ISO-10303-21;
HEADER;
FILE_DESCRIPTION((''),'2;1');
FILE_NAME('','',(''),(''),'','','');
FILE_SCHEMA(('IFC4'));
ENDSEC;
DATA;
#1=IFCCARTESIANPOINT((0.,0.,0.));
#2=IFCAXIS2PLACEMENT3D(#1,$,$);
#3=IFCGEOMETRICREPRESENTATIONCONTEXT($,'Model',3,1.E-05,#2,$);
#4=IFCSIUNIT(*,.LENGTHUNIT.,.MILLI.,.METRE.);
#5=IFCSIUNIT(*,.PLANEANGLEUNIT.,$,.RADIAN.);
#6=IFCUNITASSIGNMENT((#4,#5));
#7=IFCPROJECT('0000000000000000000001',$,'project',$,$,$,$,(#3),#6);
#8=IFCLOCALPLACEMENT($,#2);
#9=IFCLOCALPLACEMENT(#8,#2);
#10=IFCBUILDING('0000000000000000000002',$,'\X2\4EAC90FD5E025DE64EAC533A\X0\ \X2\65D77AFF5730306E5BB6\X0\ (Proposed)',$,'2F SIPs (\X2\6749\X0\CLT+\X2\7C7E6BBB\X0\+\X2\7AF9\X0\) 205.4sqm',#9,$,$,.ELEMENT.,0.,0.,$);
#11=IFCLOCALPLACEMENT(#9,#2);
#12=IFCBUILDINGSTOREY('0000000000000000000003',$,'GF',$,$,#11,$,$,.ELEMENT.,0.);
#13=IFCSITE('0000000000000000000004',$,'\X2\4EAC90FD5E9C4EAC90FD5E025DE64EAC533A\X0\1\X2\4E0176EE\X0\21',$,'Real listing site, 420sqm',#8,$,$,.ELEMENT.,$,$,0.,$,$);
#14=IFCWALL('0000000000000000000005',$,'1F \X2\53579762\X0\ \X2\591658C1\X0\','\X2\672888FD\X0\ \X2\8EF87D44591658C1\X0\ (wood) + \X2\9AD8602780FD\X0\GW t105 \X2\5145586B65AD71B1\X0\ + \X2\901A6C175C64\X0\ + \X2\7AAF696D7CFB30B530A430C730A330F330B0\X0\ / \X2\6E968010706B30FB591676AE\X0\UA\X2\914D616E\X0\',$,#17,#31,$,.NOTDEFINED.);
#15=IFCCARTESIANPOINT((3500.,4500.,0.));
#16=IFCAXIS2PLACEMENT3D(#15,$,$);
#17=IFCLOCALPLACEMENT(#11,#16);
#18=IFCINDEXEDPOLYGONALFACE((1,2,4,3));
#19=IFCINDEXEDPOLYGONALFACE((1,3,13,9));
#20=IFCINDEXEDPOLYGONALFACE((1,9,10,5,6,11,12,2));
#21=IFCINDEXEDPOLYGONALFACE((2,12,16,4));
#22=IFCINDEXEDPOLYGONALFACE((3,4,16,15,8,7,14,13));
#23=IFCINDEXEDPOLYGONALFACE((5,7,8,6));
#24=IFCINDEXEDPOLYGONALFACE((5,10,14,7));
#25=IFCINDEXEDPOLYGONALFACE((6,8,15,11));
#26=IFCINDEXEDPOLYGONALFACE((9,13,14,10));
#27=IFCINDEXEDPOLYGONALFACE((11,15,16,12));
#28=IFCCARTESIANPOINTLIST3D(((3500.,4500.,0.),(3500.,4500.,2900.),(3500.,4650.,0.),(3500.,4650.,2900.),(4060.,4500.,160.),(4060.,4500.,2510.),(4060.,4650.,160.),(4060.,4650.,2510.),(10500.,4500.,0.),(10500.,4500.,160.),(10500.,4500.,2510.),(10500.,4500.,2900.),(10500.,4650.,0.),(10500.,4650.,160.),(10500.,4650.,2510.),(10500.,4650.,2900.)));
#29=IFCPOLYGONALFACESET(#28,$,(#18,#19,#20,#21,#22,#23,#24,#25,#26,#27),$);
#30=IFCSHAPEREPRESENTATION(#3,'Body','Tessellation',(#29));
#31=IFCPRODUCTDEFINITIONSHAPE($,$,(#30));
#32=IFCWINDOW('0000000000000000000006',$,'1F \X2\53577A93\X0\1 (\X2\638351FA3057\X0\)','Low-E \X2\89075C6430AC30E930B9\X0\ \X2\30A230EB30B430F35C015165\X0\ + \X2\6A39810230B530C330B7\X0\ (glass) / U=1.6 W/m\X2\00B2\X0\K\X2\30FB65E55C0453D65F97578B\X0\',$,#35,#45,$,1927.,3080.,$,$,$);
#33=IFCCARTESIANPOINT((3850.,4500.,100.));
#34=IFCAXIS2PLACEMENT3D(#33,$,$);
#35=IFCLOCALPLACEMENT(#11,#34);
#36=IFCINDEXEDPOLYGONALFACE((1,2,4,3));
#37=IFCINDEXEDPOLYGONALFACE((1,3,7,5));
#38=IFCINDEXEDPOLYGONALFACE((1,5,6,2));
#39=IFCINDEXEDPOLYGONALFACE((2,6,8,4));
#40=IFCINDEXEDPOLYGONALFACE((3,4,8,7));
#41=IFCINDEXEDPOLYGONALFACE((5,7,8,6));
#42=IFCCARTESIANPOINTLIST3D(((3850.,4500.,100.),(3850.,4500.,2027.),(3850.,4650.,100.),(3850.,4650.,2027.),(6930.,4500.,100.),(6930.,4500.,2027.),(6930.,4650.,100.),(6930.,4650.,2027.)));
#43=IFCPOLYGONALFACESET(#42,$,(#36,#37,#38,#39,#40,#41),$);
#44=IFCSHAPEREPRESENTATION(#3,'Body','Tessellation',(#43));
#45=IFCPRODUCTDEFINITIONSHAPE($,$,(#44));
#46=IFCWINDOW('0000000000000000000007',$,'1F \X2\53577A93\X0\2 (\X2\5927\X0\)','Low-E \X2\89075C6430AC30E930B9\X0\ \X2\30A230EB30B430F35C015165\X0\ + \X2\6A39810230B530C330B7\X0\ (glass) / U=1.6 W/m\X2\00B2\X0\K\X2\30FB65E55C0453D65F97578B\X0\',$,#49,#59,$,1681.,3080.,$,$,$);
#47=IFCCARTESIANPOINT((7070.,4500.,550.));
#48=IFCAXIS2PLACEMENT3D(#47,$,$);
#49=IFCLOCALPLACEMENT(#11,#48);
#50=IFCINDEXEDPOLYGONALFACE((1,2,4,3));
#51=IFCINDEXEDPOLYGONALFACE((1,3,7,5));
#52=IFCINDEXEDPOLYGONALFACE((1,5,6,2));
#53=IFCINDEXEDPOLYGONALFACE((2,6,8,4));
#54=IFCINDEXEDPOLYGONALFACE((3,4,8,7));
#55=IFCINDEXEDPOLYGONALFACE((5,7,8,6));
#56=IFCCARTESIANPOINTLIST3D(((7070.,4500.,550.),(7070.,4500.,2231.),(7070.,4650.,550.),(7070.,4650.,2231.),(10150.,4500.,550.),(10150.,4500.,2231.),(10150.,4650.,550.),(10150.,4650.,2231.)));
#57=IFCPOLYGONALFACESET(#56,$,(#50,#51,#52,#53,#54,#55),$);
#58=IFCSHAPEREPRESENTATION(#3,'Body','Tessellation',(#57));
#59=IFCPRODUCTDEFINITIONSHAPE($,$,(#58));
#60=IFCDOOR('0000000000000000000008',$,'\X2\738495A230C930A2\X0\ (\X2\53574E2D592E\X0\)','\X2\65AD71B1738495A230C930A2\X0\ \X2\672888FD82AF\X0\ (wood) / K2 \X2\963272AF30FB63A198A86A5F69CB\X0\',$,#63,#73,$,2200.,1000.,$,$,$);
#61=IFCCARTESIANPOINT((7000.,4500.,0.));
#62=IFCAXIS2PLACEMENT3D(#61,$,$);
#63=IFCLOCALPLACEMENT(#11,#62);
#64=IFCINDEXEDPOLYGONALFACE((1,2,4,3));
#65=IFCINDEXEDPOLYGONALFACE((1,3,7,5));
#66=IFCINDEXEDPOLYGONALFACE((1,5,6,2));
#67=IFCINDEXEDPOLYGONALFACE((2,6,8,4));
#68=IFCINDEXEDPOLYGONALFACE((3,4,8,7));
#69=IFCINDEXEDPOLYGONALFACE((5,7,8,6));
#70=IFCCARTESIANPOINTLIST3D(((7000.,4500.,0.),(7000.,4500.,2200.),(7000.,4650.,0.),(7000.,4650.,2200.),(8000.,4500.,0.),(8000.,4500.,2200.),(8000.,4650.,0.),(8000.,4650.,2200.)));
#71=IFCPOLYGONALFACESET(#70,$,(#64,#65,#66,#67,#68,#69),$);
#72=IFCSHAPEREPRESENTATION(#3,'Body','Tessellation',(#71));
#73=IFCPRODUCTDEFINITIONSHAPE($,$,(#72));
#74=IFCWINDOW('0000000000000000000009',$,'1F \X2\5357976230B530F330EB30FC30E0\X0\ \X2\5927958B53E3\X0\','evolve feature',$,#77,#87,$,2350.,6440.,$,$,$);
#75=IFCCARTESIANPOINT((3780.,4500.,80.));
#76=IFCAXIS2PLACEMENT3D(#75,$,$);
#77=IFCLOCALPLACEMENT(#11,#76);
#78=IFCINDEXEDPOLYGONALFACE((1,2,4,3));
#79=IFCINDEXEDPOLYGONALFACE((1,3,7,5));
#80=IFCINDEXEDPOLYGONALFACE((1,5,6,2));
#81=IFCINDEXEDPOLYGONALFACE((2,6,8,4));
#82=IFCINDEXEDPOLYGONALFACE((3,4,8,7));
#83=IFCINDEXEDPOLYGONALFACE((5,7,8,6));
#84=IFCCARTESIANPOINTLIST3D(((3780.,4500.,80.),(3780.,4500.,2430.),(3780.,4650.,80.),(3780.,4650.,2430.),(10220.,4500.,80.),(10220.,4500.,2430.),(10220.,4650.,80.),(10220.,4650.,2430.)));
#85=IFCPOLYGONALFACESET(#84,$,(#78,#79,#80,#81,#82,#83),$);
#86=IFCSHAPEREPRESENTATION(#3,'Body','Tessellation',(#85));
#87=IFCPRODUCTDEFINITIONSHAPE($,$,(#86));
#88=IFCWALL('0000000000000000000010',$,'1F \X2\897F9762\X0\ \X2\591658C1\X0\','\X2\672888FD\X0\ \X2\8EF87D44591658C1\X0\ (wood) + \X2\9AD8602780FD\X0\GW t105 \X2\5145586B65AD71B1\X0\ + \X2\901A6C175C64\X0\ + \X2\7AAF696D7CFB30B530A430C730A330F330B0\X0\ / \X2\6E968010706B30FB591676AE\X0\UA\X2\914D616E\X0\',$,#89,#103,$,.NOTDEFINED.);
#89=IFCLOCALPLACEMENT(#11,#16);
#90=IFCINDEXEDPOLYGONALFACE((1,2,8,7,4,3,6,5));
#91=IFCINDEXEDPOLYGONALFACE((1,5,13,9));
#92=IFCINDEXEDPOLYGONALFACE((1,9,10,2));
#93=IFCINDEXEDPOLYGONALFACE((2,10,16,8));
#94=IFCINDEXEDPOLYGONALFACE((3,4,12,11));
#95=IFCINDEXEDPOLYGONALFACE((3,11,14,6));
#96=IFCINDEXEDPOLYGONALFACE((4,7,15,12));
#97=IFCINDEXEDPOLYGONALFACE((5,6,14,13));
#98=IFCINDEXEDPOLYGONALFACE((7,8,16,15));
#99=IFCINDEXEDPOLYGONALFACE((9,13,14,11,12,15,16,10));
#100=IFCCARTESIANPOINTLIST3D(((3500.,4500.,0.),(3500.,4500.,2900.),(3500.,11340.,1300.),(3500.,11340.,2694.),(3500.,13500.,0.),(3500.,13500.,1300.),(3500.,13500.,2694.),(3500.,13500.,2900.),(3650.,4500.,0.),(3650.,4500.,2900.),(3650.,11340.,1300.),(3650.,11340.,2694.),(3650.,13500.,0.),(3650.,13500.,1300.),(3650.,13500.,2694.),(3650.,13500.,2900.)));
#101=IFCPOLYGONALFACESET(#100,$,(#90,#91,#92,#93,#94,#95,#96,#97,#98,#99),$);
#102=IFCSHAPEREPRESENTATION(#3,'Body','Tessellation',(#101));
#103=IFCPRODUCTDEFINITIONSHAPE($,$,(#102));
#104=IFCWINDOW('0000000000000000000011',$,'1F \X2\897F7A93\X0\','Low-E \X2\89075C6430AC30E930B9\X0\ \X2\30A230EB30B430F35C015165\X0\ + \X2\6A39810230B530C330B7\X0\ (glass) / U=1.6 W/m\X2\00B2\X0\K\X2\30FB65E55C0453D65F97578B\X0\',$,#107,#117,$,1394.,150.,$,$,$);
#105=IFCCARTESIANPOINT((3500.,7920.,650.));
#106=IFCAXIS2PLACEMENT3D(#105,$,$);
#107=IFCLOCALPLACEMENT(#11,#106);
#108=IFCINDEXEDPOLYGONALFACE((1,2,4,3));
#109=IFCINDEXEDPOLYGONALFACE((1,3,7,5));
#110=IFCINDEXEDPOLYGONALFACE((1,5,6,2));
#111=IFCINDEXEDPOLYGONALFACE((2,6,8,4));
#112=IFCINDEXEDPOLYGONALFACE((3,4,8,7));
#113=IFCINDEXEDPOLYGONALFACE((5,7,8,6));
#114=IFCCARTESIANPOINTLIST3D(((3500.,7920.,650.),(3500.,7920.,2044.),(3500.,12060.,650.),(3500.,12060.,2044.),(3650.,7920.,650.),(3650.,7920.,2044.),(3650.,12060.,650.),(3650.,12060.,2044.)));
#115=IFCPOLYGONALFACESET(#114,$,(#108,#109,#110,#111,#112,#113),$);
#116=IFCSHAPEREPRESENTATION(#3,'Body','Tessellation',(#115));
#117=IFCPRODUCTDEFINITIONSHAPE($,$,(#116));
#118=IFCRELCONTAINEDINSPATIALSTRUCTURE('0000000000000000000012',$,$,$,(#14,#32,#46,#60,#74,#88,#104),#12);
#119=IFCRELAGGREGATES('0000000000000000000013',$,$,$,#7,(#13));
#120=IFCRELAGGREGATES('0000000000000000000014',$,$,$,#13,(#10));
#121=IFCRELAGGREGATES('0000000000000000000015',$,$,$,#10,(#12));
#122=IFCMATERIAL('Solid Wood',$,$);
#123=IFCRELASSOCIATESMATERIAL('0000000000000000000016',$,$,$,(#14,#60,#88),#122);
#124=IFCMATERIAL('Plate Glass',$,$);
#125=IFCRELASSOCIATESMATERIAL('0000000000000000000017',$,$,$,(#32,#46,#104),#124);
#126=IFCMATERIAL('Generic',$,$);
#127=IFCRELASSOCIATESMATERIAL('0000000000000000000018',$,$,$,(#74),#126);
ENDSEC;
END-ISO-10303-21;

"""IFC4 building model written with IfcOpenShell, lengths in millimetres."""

from ifc_helpers import new_model, si_unit, frame, frame_2d, origin, place, context, project, spatial, rectangle, extrude, material, element, fill, save


model = new_model("IFC4")

# Units and contexts
model_context = context("Model", 3, precision=1e-05, world=origin())
ifc_project = project(units=[si_unit("LENGTHUNIT", "METRE", prefix="MILLI"), si_unit("PLANEANGLEUNIT", "RADIAN")], contexts=[model_context])

# Site, building, storey
site_placement = place(None, origin())
site = spatial("IfcSite", under=ifc_project, at=site_placement, Name="京都府京都市左京区1丁目21", ObjectType="Real listing site, 420sqm", CompositionType="ELEMENT", RefElevation=0.0)
building_placement = place(site_placement, origin())
building = spatial("IfcBuilding", under=site, at=building_placement, Name="京都市左京区 旗竿地の家 (Proposed)", ObjectType="2F SIPs (杉CLT+籾殻+竹) 205.4sqm", CompositionType="ELEMENT", ElevationOfRefHeight=0.0, ElevationOfTerrain=0.0)
storey_placement = place(building_placement, origin())
storey = spatial("IfcBuildingStorey", under=building, at=storey_placement, Name="GF", CompositionType="ELEMENT", Elevation=0.0)

# Shared definitions
ifc_material_1 = material(Name="Solid Wood")
ifc_material_2 = material(Name="Generic")

# Wall, openings, windows, door
wall_1_placement = place(storey_placement, frame((3500.0, 4500.0, 0.0)))
wall_1 = element("IfcWall", 1, at=wall_1_placement, inside=storey, material=ifc_material_1, Name="1F 南面 外壁", Description="木製 軸組外壁 (wood) + 高性能GW t105 充填断熱 + 通気層 + 窯業系サイディング / 準耐火・外皮UA配慮", PredefinedType="NOTDEFINED", context=model_context, shape_type="SweptSolid", body=[
    extrude(rectangle(XDim=7000.0, YDim=150.0, at=frame_2d((3500.0, 75.0))), frame((3500.0, 4500.0, 0.0)), (0.0, 0.0, 1.0), 2900.0),
])
opening_1_placement = place(storey_placement, frame((3850.0, 4500.0, 100.0)))
opening_1 = element("IfcOpeningElement", 2, at=opening_1_placement, cuts=wall_1, PredefinedType="NOTDEFINED", context=model_context, shape_type="SweptSolid", body=[
    extrude(rectangle(XDim=3080.0, YDim=150.0, at=frame_2d((1540.0, 75.0))), frame((3850.0, 4500.0, 100.0)), (0.0, 0.0, 1.0), 1927.0),
])
opening_2_placement = place(storey_placement, frame((7070.0, 4500.0, 550.0)))
opening_2 = element("IfcOpeningElement", 3, at=opening_2_placement, cuts=wall_1, PredefinedType="NOTDEFINED", context=model_context, shape_type="SweptSolid", body=[
    extrude(rectangle(XDim=3080.0, YDim=150.0, at=frame_2d((1540.0, 75.0))), frame((7070.0, 4500.0, 550.0)), (0.0, 0.0, 1.0), 1681.0),
])
opening_3_placement = place(storey_placement, frame((7000.0, 4500.0, 0.0)))
opening_3 = element("IfcOpeningElement", 4, at=opening_3_placement, cuts=wall_1, PredefinedType="NOTDEFINED", context=model_context, shape_type="SweptSolid", body=[
    extrude(rectangle(XDim=1000.0, YDim=150.0, at=frame_2d((500.0, 75.0))), frame((7000.0, 4500.0, 0.0)), (0.0, 0.0, 1.0), 2200.0),
])
opening_4_placement = place(storey_placement, frame((3780.0, 4500.0, 80.0)))
opening_4 = element("IfcOpeningElement", 5, at=opening_4_placement, cuts=wall_1, PredefinedType="NOTDEFINED", context=model_context, shape_type="SweptSolid", body=[
    extrude(rectangle(XDim=6440.0, YDim=150.0, at=frame_2d((3220.0, 75.0))), frame((3780.0, 4500.0, 80.0)), (0.0, 0.0, 1.0), 2350.0),
])
ifc_material_3 = material(Name="Plate Glass")
window_1_placement = place(storey_placement, frame((3850.0, 4500.0, 100.0)))
window_1 = element("IfcWindow", 6, at=window_1_placement, inside=storey, material=ifc_material_3, Name="1F 南窓1 (掃出し)", Description="Low-E 複層ガラス アルゴン封入 + 樹脂サッシ (glass) / U=1.6 W/m²K・日射取得型", OverallHeight=1927.0, OverallWidth=3080.0, context=model_context, shape_type="SweptSolid", body=[
    extrude(rectangle(XDim=3080.0, YDim=150.0, at=frame_2d((1540.0, 75.0))), frame((3850.0, 4500.0, 100.0)), (0.0, 0.0, 1.0), 1927.0),
])
fill(opening_1, window_1)
window_2_placement = place(storey_placement, frame((7070.0, 4500.0, 550.0)))
window_2 = element("IfcWindow", 7, at=window_2_placement, inside=storey, material=ifc_material_3, Name="1F 南窓2 (大)", Description="Low-E 複層ガラス アルゴン封入 + 樹脂サッシ (glass) / U=1.6 W/m²K・日射取得型", OverallHeight=1681.0, OverallWidth=3080.0, context=model_context, shape_type="SweptSolid", body=[
    extrude(rectangle(XDim=3080.0, YDim=150.0, at=frame_2d((1540.0, 75.0))), frame((7070.0, 4500.0, 550.0)), (0.0, 0.0, 1.0), 1681.0),
])
fill(opening_2, window_2)
door_placement = place(storey_placement, frame((7000.0, 4500.0, 0.0)))
door = element("IfcDoor", 8, at=door_placement, inside=storey, material=ifc_material_1, Name="玄関ドア (南中央)", Description="断熱玄関ドア 木製芯 (wood) / K2 防犯・採風機構", OverallHeight=2200.0, OverallWidth=1000.0, context=model_context, shape_type="SweptSolid", body=[
    extrude(rectangle(XDim=1000.0, YDim=150.0, at=frame_2d((500.0, 75.0))), frame((7000.0, 4500.0, 0.0)), (0.0, 0.0, 1.0), 2200.0),
])
fill(opening_3, door)
window_3_placement = place(storey_placement, frame((3780.0, 4500.0, 80.0)))
window_3 = element("IfcWindow", 9, at=window_3_placement, inside=storey, material=ifc_material_2, Name="1F 南面サンルーム 大開口", Description="evolve feature", OverallHeight=2350.0, OverallWidth=6440.0, context=model_context, shape_type="SweptSolid", body=[
    extrude(rectangle(XDim=6440.0, YDim=150.0, at=frame_2d((3220.0, 75.0))), frame((3780.0, 4500.0, 80.0)), (0.0, 0.0, 1.0), 2350.0),
])
fill(opening_4, window_3)

# Wall, opening, window
wall_2_placement = place(storey_placement, frame((3500.0, 4500.0, 0.0)))
wall_2 = element("IfcWall", 10, at=wall_2_placement, inside=storey, material=ifc_material_1, Name="1F 西面 外壁", Description="木製 軸組外壁 (wood) + 高性能GW t105 充填断熱 + 通気層 + 窯業系サイディング / 準耐火・外皮UA配慮", PredefinedType="NOTDEFINED", context=model_context, shape_type="SweptSolid", body=[
    extrude(rectangle(XDim=150.0, YDim=9000.0, at=frame_2d((75.0, 4500.0))), frame((3500.0, 4500.0, 0.0)), (0.0, 0.0, 1.0), 2900.0),
])
opening_5_placement = place(storey_placement, frame((3500.0, 7920.0, 650.0)))
opening_5 = element("IfcOpeningElement", 11, at=opening_5_placement, cuts=wall_2, PredefinedType="NOTDEFINED", context=model_context, shape_type="SweptSolid", body=[
    extrude(rectangle(XDim=150.0, YDim=4140.0, at=frame_2d((75.0, 2070.0))), frame((3500.0, 7920.0, 650.0)), (0.0, 0.0, 1.0), 1394.0),
])
window_4_placement = place(storey_placement, frame((3500.0, 7920.0, 650.0)))
window_4 = element("IfcWindow", 12, at=window_4_placement, inside=storey, material=ifc_material_3, Name="1F 西窓", Description="Low-E 複層ガラス アルゴン封入 + 樹脂サッシ (glass) / U=1.6 W/m²K・日射取得型", OverallHeight=1394.0, OverallWidth=150.0, context=model_context, shape_type="SweptSolid", body=[
    extrude(rectangle(XDim=150.0, YDim=4140.0, at=frame_2d((75.0, 2070.0))), frame((3500.0, 7920.0, 650.0)), (0.0, 0.0, 1.0), 1394.0),
])
fill(opening_5, window_4)

save(model, "model.ifc")
